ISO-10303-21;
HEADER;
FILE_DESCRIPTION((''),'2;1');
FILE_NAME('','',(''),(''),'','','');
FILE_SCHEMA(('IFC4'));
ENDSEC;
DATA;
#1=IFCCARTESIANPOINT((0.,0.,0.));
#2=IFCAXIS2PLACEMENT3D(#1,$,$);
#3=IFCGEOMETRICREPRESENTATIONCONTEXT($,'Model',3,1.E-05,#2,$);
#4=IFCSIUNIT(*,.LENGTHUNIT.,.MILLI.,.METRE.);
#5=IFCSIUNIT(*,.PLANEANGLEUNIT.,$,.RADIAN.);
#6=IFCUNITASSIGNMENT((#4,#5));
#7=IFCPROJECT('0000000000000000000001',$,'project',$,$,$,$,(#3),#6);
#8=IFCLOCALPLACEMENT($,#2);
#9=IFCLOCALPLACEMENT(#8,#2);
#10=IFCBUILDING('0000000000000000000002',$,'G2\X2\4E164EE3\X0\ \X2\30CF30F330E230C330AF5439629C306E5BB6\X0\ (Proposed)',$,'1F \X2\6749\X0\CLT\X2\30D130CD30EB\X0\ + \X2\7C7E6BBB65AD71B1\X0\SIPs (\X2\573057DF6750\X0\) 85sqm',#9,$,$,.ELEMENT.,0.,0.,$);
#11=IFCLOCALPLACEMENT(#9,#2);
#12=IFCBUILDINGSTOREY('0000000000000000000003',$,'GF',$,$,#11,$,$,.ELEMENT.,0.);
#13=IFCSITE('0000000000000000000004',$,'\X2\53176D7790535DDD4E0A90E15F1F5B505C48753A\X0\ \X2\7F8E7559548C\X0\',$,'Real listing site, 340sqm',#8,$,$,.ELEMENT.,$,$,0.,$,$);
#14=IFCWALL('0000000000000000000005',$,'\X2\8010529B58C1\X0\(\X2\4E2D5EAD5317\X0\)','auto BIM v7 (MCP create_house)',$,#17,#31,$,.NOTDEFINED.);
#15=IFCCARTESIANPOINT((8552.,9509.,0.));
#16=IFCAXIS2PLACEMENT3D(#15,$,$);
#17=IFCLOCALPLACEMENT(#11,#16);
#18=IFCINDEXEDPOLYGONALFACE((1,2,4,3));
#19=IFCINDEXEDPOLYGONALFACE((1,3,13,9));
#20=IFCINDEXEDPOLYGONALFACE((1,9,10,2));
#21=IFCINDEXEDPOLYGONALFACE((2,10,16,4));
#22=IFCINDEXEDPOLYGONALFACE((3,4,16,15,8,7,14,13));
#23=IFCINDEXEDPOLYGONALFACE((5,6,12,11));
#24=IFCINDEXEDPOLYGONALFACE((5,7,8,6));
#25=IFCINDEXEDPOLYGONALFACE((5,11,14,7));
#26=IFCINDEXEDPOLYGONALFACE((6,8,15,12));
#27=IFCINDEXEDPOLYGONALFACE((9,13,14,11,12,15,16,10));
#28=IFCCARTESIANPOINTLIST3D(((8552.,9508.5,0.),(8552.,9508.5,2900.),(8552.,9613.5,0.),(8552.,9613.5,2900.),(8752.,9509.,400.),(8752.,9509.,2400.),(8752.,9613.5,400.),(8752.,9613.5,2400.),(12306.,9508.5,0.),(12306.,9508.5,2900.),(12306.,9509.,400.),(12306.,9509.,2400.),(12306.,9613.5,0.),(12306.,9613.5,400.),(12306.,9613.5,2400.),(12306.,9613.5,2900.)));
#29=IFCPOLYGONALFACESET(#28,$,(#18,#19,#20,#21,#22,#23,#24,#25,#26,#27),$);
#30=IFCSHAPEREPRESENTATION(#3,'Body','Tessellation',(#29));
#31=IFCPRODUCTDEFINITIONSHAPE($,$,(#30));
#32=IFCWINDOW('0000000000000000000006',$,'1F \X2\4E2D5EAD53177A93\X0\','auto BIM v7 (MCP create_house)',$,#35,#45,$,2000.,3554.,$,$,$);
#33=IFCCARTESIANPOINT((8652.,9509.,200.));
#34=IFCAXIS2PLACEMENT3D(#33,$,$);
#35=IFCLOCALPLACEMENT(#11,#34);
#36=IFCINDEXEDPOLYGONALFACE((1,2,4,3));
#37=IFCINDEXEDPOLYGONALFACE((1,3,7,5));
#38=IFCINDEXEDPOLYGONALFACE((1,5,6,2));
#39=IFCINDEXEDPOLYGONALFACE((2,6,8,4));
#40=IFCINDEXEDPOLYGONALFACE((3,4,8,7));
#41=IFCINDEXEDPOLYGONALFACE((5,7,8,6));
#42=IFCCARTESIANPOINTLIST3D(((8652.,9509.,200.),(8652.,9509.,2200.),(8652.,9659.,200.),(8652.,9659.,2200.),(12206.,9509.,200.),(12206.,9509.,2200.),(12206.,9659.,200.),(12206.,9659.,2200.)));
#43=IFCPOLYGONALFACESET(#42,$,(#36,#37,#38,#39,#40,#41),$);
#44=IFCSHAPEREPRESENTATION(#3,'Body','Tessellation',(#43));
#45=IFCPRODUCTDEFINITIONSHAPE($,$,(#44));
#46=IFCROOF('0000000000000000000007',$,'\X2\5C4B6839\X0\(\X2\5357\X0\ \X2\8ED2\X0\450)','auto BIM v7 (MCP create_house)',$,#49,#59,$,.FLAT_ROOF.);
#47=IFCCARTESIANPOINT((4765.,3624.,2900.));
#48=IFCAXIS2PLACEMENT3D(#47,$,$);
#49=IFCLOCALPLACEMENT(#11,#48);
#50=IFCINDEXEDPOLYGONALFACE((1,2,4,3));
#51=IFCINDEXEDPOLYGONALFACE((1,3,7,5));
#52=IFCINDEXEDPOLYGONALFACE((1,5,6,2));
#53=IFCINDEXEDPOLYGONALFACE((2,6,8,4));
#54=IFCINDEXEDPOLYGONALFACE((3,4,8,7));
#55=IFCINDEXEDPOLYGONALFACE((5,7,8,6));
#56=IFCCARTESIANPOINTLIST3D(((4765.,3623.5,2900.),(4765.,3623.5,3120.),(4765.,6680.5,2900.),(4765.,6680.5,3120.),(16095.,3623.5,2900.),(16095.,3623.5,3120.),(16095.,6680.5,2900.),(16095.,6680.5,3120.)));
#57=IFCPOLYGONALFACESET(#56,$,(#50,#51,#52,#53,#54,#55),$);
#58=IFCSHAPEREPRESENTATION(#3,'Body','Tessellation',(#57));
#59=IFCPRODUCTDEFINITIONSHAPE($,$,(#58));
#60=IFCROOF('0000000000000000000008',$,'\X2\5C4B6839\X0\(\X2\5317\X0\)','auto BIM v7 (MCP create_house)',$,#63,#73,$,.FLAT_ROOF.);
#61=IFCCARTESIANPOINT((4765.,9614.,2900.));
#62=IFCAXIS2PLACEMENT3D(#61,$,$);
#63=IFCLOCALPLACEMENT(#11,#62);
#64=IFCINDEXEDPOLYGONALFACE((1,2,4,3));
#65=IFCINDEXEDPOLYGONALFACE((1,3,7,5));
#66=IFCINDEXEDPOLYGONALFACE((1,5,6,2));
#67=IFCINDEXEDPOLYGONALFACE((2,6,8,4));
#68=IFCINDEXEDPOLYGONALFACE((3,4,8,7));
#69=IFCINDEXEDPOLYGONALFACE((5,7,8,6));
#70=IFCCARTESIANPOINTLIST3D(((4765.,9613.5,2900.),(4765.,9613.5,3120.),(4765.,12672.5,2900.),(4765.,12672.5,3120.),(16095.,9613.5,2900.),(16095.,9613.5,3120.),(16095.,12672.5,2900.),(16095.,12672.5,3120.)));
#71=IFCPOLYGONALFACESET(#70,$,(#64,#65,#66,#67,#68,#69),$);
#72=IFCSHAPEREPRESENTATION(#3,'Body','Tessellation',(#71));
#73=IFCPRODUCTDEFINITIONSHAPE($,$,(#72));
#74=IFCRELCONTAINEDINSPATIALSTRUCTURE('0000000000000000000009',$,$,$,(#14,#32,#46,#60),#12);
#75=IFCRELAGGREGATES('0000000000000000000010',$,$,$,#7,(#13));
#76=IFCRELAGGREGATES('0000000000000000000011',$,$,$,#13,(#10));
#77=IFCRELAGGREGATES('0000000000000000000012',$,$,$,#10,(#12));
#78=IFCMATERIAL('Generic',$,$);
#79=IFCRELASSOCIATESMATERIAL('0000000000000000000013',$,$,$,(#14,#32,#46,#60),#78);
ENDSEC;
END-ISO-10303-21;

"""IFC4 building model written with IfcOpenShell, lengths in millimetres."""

from ifc_helpers import new_model, si_unit, frame, frame_2d, origin, place, context, project, spatial, rectangle, extrude, material, element, fill, save


model = new_model("IFC4")

# Units and contexts
model_context = context("Model", 3, precision=1e-05, world=origin())
ifc_project = project(units=[si_unit("LENGTHUNIT", "METRE", prefix="MILLI"), si_unit("PLANEANGLEUNIT", "RADIAN")], contexts=[model_context])

# Site, building, storey
site_placement = place(None, origin())
site = spatial("IfcSite", under=ifc_project, at=site_placement, Name="北海道川上郡弟子屈町 美留和", ObjectType="Real listing site, 340sqm", CompositionType="ELEMENT", RefElevation=0.0)
building_placement = place(site_placement, origin())
building = spatial("IfcBuilding", under=site, at=building_placement, Name="G2世代 ハンモック吹抜の家 (Proposed)", ObjectType="1F 杉CLTパネル + 籾殻断熱SIPs (地域材) 85sqm", CompositionType="ELEMENT", ElevationOfRefHeight=0.0, ElevationOfTerrain=0.0)
storey_placement = place(building_placement, origin())
storey = spatial("IfcBuildingStorey", under=building, at=storey_placement, Name="GF", CompositionType="ELEMENT", Elevation=0.0)

# Shared definitions
ifc_material = material(Name="Generic")

# Wall, opening, window
wall_1_placement = place(storey_placement, frame((8552.0, 9509.0, 0.0)))
wall_1 = element("IfcWall", 1, at=wall_1_placement, inside=storey, material=ifc_material, Name="耐力壁(中庭北)", Description="auto BIM v7 (MCP create_house)", PredefinedType="NOTDEFINED", context=model_context, shape_type="SweptSolid", body=[
    extrude(rectangle(XDim=3754.0, YDim=105.0, at=frame_2d((1877.0, 52.0))), frame((8552.0, 9509.0, 0.0)), (0.0, 0.0, 1.0), 2900.0),
])
opening_1_placement = place(storey_placement, frame((8652.0, 9509.0, 200.0)))
opening_1 = element("IfcOpeningElement", 2, at=opening_1_placement, cuts=wall_1, PredefinedType="NOTDEFINED", context=model_context, shape_type="SweptSolid", body=[
    extrude(rectangle(XDim=3554.0, YDim=150.0, at=frame_2d((1777.0, 75.0))), frame((8652.0, 9509.0, 200.0)), (0.0, 0.0, 1.0), 2000.0),
])
window_1_placement = place(storey_placement, frame((8652.0, 9509.0, 200.0)))
window_1 = element("IfcWindow", 3, at=window_1_placement, inside=storey, material=ifc_material, Name="1F 中庭北窓", Description="auto BIM v7 (MCP create_house)", OverallHeight=2000.0, OverallWidth=3554.0, context=model_context, shape_type="SweptSolid", body=[
    extrude(rectangle(XDim=3554.0, YDim=150.0, at=frame_2d((1777.0, 75.0))), frame((8652.0, 9509.0, 200.0)), (0.0, 0.0, 1.0), 2000.0),
])
fill(opening_1, window_1)

# Roofs
roof_1_placement = place(storey_placement, frame((4765.0, 3624.0, 2900.0)))
element("IfcRoof", 4, at=roof_1_placement, inside=storey, material=ifc_material, Name="屋根(南 軒450)", Description="auto BIM v7 (MCP create_house)", PredefinedType="FLAT_ROOF", context=model_context, shape_type="SweptSolid", body=[
    extrude(rectangle(XDim=11330.0, YDim=3057.0, at=frame_2d((5665.0, 1528.0))), frame((4765.0, 3624.0, 2900.0)), (0.0, 0.0, 1.0), 220.0),
])
roof_2_placement = place(storey_placement, frame((4765.0, 9614.0, 2900.0)))
element("IfcRoof", 5, at=roof_2_placement, inside=storey, material=ifc_material, Name="屋根(北)", Description="auto BIM v7 (MCP create_house)", PredefinedType="FLAT_ROOF", context=model_context, shape_type="SweptSolid", body=[
    extrude(rectangle(XDim=11330.0, YDim=3059.0, at=frame_2d((5665.0, 1529.0))), frame((4765.0, 9614.0, 2900.0)), (0.0, 0.0, 1.0), 220.0),
])

save(model, "model.ifc")
